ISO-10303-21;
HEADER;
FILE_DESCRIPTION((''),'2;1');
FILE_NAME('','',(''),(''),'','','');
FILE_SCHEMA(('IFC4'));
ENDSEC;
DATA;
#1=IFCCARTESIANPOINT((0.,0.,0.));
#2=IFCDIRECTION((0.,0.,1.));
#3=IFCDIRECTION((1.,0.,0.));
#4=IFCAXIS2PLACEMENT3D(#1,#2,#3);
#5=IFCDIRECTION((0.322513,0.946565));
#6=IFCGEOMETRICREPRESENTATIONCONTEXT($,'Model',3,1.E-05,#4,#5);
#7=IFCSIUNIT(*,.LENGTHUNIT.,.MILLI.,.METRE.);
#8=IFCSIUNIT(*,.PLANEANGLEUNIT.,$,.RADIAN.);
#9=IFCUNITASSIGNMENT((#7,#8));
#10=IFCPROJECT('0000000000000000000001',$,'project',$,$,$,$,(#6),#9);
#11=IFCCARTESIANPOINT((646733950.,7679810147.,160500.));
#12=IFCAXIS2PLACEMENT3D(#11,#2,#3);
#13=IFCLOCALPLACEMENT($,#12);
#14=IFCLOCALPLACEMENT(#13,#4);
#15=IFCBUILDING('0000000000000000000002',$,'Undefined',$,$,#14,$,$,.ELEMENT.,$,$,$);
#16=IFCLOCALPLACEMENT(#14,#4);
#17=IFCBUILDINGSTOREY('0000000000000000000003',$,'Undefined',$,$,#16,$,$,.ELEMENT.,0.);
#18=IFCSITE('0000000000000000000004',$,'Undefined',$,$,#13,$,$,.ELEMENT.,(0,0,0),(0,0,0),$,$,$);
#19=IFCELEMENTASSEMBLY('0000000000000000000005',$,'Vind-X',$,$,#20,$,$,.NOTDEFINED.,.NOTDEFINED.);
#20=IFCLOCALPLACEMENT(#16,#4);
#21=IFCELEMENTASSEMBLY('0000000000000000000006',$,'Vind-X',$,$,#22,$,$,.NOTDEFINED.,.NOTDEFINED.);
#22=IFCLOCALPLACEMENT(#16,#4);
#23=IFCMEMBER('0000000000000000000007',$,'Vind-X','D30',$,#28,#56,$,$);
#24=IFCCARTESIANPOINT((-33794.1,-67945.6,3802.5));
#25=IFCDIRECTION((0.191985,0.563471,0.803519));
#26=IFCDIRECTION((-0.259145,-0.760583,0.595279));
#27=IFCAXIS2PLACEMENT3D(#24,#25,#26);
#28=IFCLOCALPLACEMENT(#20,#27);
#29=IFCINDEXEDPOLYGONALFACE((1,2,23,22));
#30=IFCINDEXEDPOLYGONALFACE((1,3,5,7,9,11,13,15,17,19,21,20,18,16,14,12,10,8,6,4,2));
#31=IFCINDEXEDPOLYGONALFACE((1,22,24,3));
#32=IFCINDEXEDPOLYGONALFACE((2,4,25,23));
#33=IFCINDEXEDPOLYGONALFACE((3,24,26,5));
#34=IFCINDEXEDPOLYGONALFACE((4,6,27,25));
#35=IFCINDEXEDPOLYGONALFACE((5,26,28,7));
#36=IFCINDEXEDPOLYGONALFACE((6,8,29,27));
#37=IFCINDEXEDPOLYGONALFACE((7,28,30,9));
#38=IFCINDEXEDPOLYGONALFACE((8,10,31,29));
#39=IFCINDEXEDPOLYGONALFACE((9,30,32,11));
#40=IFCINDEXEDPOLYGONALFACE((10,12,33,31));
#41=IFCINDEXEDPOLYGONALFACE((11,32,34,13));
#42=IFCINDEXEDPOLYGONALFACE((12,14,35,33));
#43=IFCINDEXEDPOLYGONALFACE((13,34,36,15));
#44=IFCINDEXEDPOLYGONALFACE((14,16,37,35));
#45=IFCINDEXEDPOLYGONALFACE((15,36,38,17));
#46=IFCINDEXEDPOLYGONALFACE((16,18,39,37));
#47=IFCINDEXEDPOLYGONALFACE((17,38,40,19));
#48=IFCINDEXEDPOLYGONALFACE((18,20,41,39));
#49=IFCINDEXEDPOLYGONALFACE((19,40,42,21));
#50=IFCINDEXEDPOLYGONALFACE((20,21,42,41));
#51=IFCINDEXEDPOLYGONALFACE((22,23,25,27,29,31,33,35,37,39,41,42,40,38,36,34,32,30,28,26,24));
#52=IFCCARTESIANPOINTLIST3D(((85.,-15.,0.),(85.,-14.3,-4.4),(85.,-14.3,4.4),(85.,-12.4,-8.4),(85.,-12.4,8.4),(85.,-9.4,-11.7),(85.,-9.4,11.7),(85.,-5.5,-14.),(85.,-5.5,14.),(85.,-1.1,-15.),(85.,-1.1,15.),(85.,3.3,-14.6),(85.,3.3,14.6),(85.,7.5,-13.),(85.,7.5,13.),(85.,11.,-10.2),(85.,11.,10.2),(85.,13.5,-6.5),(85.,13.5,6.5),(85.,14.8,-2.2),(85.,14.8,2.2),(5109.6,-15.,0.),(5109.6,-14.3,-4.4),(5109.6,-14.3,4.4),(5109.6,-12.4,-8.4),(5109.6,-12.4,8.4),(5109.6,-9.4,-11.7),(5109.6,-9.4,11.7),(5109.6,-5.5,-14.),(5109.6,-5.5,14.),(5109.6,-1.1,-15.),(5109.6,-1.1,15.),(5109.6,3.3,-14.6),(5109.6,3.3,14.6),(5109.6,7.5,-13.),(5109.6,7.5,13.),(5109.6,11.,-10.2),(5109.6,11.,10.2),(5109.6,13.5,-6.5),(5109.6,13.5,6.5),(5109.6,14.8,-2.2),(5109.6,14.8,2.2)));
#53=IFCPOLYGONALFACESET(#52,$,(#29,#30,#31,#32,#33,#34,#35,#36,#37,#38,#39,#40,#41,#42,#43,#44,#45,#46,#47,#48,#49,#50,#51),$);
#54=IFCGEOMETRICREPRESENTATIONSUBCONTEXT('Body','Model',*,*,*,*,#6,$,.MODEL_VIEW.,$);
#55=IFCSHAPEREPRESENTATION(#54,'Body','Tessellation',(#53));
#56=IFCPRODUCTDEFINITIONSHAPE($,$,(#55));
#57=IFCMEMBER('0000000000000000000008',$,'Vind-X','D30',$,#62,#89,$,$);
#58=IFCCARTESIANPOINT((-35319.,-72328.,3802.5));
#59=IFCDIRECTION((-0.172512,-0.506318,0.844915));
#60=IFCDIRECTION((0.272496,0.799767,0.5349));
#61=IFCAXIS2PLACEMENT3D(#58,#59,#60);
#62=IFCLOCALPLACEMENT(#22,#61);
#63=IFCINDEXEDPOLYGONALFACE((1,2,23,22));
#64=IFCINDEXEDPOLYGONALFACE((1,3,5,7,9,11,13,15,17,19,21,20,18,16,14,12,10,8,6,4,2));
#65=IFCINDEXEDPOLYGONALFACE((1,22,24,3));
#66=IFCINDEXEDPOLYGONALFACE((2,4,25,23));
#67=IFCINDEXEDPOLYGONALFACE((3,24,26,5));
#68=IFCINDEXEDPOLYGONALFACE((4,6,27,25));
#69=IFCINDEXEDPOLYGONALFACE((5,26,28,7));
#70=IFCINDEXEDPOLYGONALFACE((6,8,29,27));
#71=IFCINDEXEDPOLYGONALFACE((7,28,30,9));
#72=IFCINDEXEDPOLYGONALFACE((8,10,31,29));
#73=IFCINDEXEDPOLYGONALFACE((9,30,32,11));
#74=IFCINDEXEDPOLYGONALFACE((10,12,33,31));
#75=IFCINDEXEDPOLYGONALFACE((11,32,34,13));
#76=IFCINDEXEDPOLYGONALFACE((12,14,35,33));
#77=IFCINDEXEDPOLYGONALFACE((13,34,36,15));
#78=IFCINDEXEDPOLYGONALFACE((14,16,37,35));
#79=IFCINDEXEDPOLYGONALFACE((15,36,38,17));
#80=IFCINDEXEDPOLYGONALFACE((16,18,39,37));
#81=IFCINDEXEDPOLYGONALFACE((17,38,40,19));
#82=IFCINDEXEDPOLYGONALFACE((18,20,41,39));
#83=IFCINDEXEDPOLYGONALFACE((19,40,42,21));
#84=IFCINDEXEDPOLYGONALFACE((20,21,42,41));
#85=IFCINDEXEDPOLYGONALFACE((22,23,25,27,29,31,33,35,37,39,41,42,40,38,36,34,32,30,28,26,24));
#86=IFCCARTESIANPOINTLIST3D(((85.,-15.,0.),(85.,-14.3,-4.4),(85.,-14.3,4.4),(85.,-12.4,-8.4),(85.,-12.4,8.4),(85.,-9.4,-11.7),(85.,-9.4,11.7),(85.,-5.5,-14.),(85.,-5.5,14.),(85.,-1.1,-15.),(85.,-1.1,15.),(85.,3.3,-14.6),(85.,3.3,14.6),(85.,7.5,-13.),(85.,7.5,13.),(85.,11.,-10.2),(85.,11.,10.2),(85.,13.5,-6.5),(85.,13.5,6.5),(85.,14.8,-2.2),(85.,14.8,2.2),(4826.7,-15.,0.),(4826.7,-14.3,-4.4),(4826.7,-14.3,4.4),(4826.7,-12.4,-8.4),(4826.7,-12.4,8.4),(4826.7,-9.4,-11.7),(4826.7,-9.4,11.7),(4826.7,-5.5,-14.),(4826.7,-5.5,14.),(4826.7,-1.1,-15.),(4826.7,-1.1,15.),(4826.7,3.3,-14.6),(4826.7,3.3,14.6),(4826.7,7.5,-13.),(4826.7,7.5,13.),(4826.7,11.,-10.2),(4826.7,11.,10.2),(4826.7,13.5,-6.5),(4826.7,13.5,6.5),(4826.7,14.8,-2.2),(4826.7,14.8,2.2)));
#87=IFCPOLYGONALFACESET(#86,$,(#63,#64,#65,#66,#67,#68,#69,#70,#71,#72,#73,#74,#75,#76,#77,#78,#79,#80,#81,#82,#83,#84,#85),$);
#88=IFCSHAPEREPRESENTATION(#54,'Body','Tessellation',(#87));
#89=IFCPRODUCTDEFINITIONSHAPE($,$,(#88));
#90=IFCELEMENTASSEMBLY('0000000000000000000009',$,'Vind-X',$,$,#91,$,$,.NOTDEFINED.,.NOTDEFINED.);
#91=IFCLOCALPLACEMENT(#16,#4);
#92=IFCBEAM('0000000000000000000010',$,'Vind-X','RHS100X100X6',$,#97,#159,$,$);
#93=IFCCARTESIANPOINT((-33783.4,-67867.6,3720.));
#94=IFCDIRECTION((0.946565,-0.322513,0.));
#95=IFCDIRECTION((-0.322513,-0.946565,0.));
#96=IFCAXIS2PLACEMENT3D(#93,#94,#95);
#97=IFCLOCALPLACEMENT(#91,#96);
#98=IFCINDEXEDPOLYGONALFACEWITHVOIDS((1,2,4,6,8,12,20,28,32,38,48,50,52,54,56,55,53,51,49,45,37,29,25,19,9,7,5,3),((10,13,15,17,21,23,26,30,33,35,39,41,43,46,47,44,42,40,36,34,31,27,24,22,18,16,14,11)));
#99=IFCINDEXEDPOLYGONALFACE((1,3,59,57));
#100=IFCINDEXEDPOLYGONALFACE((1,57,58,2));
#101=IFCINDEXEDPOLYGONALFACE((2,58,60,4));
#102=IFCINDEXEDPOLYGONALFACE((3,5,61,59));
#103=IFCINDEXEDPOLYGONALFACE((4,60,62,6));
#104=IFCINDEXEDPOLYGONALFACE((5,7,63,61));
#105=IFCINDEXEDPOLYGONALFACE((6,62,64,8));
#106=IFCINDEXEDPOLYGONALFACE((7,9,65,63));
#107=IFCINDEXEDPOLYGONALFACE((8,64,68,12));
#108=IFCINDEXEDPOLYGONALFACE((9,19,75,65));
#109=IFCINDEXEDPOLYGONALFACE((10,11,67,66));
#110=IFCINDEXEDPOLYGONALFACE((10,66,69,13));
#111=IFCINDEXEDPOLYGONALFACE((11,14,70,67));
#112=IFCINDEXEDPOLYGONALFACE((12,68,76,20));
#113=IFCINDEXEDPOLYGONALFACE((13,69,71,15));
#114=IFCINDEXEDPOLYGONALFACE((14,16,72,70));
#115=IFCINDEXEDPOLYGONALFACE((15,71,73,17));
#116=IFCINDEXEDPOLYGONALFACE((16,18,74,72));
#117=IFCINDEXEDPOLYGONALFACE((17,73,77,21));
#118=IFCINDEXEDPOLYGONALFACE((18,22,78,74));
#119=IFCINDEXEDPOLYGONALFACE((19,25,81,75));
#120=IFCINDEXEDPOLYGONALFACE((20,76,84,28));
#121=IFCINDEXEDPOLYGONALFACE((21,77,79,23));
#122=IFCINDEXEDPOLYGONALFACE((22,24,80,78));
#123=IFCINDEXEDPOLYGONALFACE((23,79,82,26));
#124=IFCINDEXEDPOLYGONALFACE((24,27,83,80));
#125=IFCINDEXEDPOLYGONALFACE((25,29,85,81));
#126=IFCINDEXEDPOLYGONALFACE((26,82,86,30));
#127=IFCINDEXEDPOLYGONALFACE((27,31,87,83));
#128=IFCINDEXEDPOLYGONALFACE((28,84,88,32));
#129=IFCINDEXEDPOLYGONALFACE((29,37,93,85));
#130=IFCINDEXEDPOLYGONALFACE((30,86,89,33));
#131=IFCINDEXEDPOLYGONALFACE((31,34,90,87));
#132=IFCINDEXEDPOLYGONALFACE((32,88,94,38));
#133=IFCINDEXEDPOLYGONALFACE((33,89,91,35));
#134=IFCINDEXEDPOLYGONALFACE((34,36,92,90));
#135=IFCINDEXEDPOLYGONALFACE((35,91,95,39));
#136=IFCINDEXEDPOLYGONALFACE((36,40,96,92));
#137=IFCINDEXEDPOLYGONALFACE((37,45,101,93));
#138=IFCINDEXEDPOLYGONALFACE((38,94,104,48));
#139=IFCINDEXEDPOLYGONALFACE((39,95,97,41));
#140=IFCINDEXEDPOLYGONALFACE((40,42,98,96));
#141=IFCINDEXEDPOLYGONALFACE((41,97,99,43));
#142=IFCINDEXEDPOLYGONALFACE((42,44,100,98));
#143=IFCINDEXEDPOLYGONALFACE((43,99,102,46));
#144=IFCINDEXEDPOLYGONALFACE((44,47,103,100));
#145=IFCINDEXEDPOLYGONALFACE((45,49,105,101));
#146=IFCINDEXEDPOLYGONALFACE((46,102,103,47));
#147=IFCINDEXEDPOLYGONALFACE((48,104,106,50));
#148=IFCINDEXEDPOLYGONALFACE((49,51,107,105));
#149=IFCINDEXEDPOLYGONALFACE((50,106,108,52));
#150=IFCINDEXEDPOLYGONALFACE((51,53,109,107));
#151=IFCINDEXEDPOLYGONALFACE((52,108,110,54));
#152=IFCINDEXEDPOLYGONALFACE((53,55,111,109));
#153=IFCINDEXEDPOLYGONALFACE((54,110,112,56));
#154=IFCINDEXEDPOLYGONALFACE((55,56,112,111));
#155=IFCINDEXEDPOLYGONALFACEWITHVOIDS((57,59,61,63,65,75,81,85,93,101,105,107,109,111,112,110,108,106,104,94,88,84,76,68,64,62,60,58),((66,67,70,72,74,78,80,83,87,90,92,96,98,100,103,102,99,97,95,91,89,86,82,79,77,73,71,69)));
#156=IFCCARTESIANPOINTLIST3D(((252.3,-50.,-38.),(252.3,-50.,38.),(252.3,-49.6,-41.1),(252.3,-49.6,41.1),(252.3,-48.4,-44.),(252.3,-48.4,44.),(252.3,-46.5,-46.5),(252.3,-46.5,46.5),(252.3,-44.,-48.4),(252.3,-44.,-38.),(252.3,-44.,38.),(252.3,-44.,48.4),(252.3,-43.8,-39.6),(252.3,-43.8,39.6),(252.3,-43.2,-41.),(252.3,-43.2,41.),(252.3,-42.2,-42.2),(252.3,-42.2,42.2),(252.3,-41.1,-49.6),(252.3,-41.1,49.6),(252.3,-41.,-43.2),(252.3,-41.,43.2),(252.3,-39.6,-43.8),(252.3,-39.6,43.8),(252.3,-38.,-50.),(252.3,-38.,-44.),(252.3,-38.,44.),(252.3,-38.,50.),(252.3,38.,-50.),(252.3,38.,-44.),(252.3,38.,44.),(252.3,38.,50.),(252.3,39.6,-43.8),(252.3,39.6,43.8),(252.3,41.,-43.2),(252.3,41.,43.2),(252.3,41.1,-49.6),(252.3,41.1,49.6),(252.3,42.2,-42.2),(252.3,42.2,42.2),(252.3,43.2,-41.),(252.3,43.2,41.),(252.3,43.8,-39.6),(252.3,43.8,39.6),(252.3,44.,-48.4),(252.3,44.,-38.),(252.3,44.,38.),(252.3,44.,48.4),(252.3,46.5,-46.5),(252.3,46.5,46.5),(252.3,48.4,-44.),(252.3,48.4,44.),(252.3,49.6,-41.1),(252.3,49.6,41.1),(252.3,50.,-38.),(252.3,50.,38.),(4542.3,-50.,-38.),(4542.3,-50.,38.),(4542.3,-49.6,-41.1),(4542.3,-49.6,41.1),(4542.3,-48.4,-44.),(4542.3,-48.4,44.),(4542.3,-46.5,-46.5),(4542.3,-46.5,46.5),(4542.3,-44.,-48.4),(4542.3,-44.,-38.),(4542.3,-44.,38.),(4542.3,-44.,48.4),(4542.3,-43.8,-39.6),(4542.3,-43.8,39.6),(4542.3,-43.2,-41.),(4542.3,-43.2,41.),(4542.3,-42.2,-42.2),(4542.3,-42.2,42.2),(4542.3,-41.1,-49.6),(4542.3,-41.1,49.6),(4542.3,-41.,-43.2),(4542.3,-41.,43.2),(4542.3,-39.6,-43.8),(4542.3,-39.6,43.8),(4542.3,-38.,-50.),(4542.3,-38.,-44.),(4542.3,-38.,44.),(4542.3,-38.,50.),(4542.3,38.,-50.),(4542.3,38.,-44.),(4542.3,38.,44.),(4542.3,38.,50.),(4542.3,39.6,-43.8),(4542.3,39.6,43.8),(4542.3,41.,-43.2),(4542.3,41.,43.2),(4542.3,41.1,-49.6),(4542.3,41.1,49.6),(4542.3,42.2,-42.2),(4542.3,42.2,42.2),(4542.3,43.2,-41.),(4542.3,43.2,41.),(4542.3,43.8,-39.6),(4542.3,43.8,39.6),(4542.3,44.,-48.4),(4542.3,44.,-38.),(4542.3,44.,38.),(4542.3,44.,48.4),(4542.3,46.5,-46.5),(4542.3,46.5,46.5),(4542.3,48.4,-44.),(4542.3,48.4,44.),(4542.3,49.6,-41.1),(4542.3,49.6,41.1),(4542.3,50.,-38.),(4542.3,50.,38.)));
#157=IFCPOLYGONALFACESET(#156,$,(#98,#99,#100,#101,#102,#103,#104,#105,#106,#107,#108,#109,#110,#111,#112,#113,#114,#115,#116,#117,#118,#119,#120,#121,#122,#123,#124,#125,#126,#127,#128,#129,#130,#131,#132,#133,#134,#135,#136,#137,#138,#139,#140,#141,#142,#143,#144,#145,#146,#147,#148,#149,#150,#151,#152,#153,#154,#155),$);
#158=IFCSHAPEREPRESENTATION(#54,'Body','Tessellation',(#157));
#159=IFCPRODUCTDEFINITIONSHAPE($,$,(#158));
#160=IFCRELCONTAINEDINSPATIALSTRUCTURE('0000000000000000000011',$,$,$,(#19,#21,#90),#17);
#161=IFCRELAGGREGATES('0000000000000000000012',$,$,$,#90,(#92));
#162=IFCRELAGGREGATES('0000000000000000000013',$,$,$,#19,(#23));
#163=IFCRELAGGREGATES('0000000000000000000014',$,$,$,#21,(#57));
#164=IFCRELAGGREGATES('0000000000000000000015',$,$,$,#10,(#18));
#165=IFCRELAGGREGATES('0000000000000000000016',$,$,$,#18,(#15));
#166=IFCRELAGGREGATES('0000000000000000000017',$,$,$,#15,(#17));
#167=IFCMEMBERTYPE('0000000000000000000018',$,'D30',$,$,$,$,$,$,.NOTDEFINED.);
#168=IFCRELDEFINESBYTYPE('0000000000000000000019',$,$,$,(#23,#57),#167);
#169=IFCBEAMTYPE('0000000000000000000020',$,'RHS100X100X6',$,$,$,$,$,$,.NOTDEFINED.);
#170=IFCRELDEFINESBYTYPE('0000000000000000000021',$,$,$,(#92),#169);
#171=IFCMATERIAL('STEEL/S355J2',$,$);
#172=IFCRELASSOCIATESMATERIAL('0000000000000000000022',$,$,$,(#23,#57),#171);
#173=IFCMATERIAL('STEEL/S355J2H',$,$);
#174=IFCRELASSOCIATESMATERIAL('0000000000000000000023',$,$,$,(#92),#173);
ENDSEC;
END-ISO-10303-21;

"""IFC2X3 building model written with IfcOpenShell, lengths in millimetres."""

from ifc_helpers import new_model, si_unit, direction, frame, origin_with_axes, origin_2d_with_axis, place, context, subcontext, project, spatial, hollow_rectangle, circle, extrude, clip, halfspace, material, type_object, element, aggregate, save


model = new_model("IFC2X3")

# Units and contexts
model_context = context("Model", 3, precision=1e-05, world=origin_with_axes(), true_north=direction((0.322513, 0.946565)))
body_context = subcontext(model_context, "Body", "Model", "MODEL_VIEW")
ifc_project = project(units=[si_unit("LENGTHUNIT", "METRE", prefix="MILLI"), si_unit("PLANEANGLEUNIT", "RADIAN")], contexts=[model_context])

# Site, building, storey
site_placement = place(None, frame((646733950.0, 7679810147.0, 160500.0), z_axis=(0.0, 0.0, 1.0), x_axis=(1.0, 0.0, 0.0)))
site = spatial("IfcSite", under=ifc_project, at=site_placement, Name="Undefined", CompositionType="ELEMENT", RefLatitude=(0, 0, 0), RefLongitude=(0, 0, 0))
building_placement = place(site_placement, origin_with_axes())
building = spatial("IfcBuilding", under=site, at=building_placement, Name="Undefined", CompositionType="ELEMENT")
storey_placement = place(building_placement, origin_with_axes())
storey = spatial("IfcBuildingStorey", under=building, at=storey_placement, Name="Undefined", CompositionType="ELEMENT", Elevation=0.0)

# Element assemblies
assembly_1_placement = place(storey_placement, origin_with_axes())
assembly_1 = element("IfcElementAssembly", 1, at=assembly_1_placement, inside=storey, Name="Vind-X", AssemblyPlace="NOTDEFINED", PredefinedType="NOTDEFINED")
ifc_material_1 = material(Name="STEEL/S355J2")
member_type_1 = type_object("IfcMemberType", Name="D30", PredefinedType="NOTDEFINED")
assembly_2_placement = place(storey_placement, origin_with_axes())
assembly_2 = element("IfcElementAssembly", 2, at=assembly_2_placement, inside=storey, Name="Vind-X", AssemblyPlace="NOTDEFINED", PredefinedType="NOTDEFINED")

# Members
member_1_placement = place(assembly_1_placement, frame((-33794.1, -67945.6, 3802.5), z_axis=(0.191985, 0.563471, 0.803519), x_axis=(-0.259145, -0.760583, 0.595279)))
member_1 = element("IfcMember", 3, at=member_1_placement, type_object=member_type_1, material=ifc_material_1, Name="Vind-X", Description="D30", context=body_context, shape_type="Clipping", body=[
    clip(clip(extrude(circle(Radius=15.0, at=origin_2d_with_axis()), frame((5774.6, 0.0, 0.0), z_axis=(-1.0, 0.0, 0.0), x_axis=(0.0, -1.0, 0.0)), (0.0, 0.0, 1.0), 5774.6), halfspace(frame((5109.6, -6.0, 10.2), z_axis=(1.0, 0.0, 0.0), x_axis=(0.0, 1.0, 0.0)), False)), halfspace(frame((85.0, -6.0, 16.0), z_axis=(1.0, 0.0, 0.0), x_axis=(0.0, 1.0, 0.0)), True)),
])
member_2_placement = place(assembly_2_placement, frame((-35319.0, -72328.0, 3802.5), z_axis=(-0.172512, -0.506318, 0.844915), x_axis=(0.272496, 0.799767, 0.5349)))
member_2 = element("IfcMember", 4, at=member_2_placement, type_object=member_type_1, material=ifc_material_1, Name="Vind-X", Description="D30", context=body_context, shape_type="Clipping", body=[
    clip(clip(extrude(circle(Radius=15.0, at=origin_2d_with_axis()), frame((5491.7, 0.0, 0.0), z_axis=(-1.0, 0.0, 0.0), x_axis=(0.0, -1.0, 0.0)), (0.0, 0.0, 1.0), 5491.7), halfspace(frame((4826.7, -6.0, 10.2), z_axis=(1.0, 0.0, 0.0), x_axis=(0.0, 1.0, 0.0)), False)), halfspace(frame((85.0, -6.0, 16.0), z_axis=(1.0, 0.0, 0.0), x_axis=(0.0, 1.0, 0.0)), True)),
])

# Element assembly, beam
assembly_3_placement = place(storey_placement, origin_with_axes())
assembly_3 = element("IfcElementAssembly", 5, at=assembly_3_placement, inside=storey, Name="Vind-X", AssemblyPlace="NOTDEFINED", PredefinedType="NOTDEFINED")
ifc_material_2 = material(Name="STEEL/S355J2H")
beam_type = type_object("IfcBeamType", Name="RHS100X100X6", PredefinedType="NOTDEFINED")
beam_placement = place(assembly_3_placement, frame((-33783.4, -67867.6, 3720.0), z_axis=(0.946565, -0.322513, 0.0), x_axis=(-0.322513, -0.946565, 0.0)))
beam = element("IfcBeam", 6, at=beam_placement, type_object=beam_type, material=ifc_material_2, Name="Vind-X", Description="RHS100X100X6", context=body_context, shape_type="Clipping", body=[
    clip(clip(extrude(hollow_rectangle(XDim=100.0, YDim=100.0, WallThickness=6.0, InnerFilletRadius=6.0, OuterFilletRadius=12.0, at=origin_2d_with_axis()), frame((4794.5, 0.0, 0.0), z_axis=(-1.0, 0.0, 0.0), x_axis=(0.0, -1.0, 0.0)), (0.0, 0.0, 1.0), 4794.5), halfspace(frame((4542.3, 22.5, 0.0), z_axis=(-1.0, 0.0, 0.0), x_axis=(0.0, 0.0, 1.0)), True)), halfspace(frame((252.3, 22.5, 0.0), z_axis=(1.0, 0.0, 0.0), x_axis=(0.0, 0.0, -1.0)), True)),
])

aggregate(assembly_3, [beam])

aggregate(assembly_1, [member_1])
aggregate(assembly_2, [member_2])

save(model, "model.ifc")
